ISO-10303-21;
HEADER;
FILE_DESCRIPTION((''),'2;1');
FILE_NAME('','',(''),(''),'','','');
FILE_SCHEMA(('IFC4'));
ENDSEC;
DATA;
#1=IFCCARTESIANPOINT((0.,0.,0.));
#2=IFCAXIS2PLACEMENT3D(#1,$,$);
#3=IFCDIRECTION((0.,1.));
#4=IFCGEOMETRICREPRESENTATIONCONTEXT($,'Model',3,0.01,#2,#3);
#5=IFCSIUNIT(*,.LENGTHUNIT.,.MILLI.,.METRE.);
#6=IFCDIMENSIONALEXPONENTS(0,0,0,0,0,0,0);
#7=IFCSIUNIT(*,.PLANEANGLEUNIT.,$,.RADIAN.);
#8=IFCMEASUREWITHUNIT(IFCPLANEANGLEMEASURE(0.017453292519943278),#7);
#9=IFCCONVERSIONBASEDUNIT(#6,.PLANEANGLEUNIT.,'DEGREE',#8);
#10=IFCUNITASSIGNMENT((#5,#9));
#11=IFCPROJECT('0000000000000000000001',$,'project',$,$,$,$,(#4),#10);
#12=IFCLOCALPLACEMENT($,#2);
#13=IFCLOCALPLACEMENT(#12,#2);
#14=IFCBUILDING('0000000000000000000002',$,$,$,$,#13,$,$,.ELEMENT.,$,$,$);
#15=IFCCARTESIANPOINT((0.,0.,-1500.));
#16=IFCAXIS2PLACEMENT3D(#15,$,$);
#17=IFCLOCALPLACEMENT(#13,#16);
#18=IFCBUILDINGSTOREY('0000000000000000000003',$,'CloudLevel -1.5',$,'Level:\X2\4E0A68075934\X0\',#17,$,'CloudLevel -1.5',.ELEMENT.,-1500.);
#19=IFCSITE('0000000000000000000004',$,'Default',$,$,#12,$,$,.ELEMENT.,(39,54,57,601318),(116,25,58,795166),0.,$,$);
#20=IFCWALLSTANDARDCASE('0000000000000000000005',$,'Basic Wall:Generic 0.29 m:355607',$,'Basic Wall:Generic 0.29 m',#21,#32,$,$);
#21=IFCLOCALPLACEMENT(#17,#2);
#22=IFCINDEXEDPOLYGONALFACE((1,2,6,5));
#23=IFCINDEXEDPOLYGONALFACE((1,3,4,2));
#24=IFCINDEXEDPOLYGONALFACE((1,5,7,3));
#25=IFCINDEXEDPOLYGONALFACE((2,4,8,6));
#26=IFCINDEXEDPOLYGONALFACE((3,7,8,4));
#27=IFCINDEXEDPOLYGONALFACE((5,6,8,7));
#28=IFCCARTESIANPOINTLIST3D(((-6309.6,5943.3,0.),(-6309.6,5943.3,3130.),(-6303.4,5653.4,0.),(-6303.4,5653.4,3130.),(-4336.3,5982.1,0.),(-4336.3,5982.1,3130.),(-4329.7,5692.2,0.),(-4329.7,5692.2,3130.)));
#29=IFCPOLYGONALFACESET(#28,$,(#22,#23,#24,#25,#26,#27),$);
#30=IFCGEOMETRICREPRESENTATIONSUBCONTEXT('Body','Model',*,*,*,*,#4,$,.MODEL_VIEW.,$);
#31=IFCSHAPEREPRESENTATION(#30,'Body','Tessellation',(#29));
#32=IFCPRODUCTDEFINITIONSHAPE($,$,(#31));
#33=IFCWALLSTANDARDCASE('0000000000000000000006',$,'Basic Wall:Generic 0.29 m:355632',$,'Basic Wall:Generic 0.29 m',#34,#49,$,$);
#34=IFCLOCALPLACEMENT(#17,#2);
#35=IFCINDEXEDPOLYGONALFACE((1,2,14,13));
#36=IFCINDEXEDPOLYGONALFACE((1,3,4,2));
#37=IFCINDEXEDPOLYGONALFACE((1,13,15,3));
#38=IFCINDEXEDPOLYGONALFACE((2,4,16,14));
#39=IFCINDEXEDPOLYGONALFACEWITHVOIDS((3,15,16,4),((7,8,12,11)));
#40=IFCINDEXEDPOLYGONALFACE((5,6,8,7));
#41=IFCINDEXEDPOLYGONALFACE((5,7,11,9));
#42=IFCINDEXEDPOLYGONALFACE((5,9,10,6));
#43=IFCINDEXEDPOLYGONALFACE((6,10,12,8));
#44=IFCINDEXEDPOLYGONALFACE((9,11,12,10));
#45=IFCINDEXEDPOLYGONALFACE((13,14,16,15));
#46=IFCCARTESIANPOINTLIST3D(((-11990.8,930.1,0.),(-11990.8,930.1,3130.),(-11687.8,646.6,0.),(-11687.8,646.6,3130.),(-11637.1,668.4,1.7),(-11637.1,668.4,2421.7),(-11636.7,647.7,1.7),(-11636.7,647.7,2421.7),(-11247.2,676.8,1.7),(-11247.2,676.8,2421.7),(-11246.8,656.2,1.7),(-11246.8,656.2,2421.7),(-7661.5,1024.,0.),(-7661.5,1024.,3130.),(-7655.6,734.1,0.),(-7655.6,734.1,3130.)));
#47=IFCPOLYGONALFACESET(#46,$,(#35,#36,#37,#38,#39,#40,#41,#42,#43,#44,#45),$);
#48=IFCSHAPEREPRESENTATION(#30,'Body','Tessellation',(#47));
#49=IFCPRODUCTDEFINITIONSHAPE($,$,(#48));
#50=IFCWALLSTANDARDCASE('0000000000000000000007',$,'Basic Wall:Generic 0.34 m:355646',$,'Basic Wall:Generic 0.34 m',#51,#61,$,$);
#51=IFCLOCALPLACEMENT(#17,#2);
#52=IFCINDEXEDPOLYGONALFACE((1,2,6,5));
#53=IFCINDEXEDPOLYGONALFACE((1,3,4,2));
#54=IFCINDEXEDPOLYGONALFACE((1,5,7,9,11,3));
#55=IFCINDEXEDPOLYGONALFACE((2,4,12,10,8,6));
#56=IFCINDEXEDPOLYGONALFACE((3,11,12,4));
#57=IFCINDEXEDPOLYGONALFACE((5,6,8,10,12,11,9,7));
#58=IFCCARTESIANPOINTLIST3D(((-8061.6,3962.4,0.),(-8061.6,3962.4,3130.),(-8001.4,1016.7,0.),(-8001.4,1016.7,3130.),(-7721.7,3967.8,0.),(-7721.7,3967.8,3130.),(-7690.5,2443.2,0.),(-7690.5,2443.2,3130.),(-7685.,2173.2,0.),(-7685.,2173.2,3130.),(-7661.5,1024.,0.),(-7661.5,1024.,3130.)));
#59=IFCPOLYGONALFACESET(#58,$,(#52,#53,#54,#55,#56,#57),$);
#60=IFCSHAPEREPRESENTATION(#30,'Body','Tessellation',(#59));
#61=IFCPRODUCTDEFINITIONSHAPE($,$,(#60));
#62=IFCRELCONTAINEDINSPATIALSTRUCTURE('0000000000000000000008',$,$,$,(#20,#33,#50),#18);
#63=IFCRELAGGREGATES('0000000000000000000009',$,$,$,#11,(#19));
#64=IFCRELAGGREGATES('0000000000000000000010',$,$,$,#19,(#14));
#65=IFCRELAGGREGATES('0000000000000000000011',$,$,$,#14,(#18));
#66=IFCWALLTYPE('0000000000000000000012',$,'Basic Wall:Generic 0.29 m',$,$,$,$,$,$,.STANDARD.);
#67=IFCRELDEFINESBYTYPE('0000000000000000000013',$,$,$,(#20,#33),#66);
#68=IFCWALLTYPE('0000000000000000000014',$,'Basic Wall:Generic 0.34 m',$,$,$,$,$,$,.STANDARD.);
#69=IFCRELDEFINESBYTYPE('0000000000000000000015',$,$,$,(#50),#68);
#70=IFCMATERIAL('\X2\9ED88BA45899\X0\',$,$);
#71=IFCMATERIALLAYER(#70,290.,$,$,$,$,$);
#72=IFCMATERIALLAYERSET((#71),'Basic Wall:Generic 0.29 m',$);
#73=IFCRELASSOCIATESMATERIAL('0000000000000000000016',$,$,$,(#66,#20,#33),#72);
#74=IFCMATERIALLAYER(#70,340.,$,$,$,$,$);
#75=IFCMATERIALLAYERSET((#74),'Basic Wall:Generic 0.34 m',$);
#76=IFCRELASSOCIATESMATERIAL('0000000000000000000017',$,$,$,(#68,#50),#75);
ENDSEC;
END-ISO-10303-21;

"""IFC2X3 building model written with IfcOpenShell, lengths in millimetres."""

from ifc_helpers import new_model, entity, si_unit, converted_unit, direction, frame, frame_2d, origin, place, context, subcontext, project, spatial, polyline, rectangle, outline, extrude, material, layer, layer_set, layer_usage, type_object, element, save


model = new_model("IFC2X3")

# Units and contexts
model_context = context("Model", 3, precision=0.01, world=origin(), true_north=direction((0.0, 1.0)))
body_context = subcontext(model_context, "Body", "Model", "MODEL_VIEW")
ifc_project = project(units=[si_unit("LENGTHUNIT", "METRE", prefix="MILLI"), converted_unit("PLANEANGLEUNIT", "DEGREE", entity("IfcPlaneAngleMeasure", 0.017453292519943278), si_unit("PLANEANGLEUNIT", "RADIAN"), dimensions=[0, 0, 0, 0, 0, 0, 0])], contexts=[model_context])

# Site, building, storey
site_placement = place(None, origin())
site = spatial("IfcSite", under=ifc_project, at=site_placement, Name="Default", CompositionType="ELEMENT", RefLatitude=(39, 54, 57, 601318), RefLongitude=(116, 25, 58, 795166), RefElevation=0.0)
building_placement = place(site_placement, origin())
building = spatial("IfcBuilding", under=site, at=building_placement, CompositionType="ELEMENT")
storey_placement = place(building_placement, frame((0.0, 0.0, -1500.0)))
storey = spatial("IfcBuildingStorey", under=building, at=storey_placement, Name="CloudLevel -1.5", ObjectType="Level:上标头", LongName="CloudLevel -1.5", CompositionType="ELEMENT", Elevation=-1500.0)

# Shared definitions
ifc_material_1 = material(Name="默认墙")

# Wall
ifc_layer_1 = layer(ifc_material_1, 290.0)
ifc_layer_set_1 = layer_set([ifc_layer_1], Name="Basic Wall:Generic 0.29 m")
ifc_layer_usage_1 = layer_usage(ifc_layer_set_1, "AXIS2", "NEGATIVE", 145.0)
wall_type_1 = type_object("IfcWallType", Name="Basic Wall:Generic 0.29 m", PredefinedType="STANDARD", material=ifc_layer_set_1)
wall_1_placement = place(storey_placement, frame((-6306.7, 5798.3, 0.0), z_axis=(0.0, 0.0, 1.0), x_axis=(0.999806, 0.019681, 0.0)))
element("IfcWallStandardCase", 1, at=wall_1_placement, inside=storey, type_object=wall_type_1, material=ifc_layer_usage_1, Name="Basic Wall:Generic 0.29 m:355607", ObjectType="Basic Wall:Generic 0.29 m", context=body_context, shape_type="SweptSolid", body=[
    extrude(outline(polyline([(1974.5, -145.0), (1973.7, 145.0), (0.0, 145.0), (0.4, -145.0), (1974.5, -145.0)])), origin(), (0.0, 0.0, 1.0), 3130.0),
])

# Wall, opening
wall_2_placement = place(storey_placement, frame((-7658.4, 879.1, 0.0), z_axis=(0.0, 0.0, 1.0), x_axis=(-0.999765, -0.021691, 0.0)))
wall_2 = element("IfcWallStandardCase", 2, at=wall_2_placement, inside=storey, type_object=wall_type_1, material=ifc_layer_usage_1, Name="Basic Wall:Generic 0.29 m:355632", ObjectType="Basic Wall:Generic 0.29 m", context=body_context, shape_type="SweptSolid", body=[
    extrude(outline(polyline([(4330.3, -145.0), (4033.5, 145.0), (3982.4, 145.0), (3592.4, 145.0), (0.4, 145.0), (0.0, -145.0), (340.0, -145.0), (3986.9, -145.0), (4330.3, -145.0)])), origin(), (0.0, 0.0, 1.0), 3130.0),
])
opening_1_placement = place(wall_2_placement, origin())
element("IfcOpeningElement", 3, at=opening_1_placement, cuts=wall_2, ObjectType="Opening", context=body_context, shape_type="SweptSolid", body=[
    extrude(rectangle(XDim=2420.0, YDim=390.0, at=frame_2d((0.0, 0.0), x_axis=(0.0, 1.0))), frame((3787.4, 124.3, 1211.7), z_axis=(0.000037, 1.0, 0.0), x_axis=(-1.0, 0.000037, 0.0)), (0.0, 0.0, 1.0), 2570.0),
])

# Wall
ifc_layer_2 = layer(ifc_material_1, 340.0)
ifc_layer_set_2 = layer_set([ifc_layer_2], Name="Basic Wall:Generic 0.34 m")
ifc_layer_usage_2 = layer_usage(ifc_layer_set_2, "AXIS2", "NEGATIVE", 170.0)
wall_type_2 = type_object("IfcWallType", Name="Basic Wall:Generic 0.34 m", PredefinedType="STANDARD", material=ifc_layer_set_2)
wall_3_placement = place(storey_placement, frame((-7831.5, 1020.1, 0.0), z_axis=(0.0, 0.0, 1.0), x_axis=(-0.020431, 0.999791, 0.0)))
element("IfcWallStandardCase", 4, at=wall_3_placement, inside=storey, type_object=wall_type_2, material=ifc_layer_usage_2, Name="Basic Wall:Generic 0.34 m:355646", ObjectType="Basic Wall:Generic 0.34 m", context=body_context, shape_type="SweptSolid", body=[
    extrude(outline(polyline([(2944.8, -170.0), (2946.4, 170.0), (0.0, 170.0), (0.4, -170.0), (1149.9, -170.0), (1419.9, -170.0), (2944.8, -170.0)])), origin(), (0.0, 0.0, 1.0), 3130.0),
])

save(model, "model.ifc")
